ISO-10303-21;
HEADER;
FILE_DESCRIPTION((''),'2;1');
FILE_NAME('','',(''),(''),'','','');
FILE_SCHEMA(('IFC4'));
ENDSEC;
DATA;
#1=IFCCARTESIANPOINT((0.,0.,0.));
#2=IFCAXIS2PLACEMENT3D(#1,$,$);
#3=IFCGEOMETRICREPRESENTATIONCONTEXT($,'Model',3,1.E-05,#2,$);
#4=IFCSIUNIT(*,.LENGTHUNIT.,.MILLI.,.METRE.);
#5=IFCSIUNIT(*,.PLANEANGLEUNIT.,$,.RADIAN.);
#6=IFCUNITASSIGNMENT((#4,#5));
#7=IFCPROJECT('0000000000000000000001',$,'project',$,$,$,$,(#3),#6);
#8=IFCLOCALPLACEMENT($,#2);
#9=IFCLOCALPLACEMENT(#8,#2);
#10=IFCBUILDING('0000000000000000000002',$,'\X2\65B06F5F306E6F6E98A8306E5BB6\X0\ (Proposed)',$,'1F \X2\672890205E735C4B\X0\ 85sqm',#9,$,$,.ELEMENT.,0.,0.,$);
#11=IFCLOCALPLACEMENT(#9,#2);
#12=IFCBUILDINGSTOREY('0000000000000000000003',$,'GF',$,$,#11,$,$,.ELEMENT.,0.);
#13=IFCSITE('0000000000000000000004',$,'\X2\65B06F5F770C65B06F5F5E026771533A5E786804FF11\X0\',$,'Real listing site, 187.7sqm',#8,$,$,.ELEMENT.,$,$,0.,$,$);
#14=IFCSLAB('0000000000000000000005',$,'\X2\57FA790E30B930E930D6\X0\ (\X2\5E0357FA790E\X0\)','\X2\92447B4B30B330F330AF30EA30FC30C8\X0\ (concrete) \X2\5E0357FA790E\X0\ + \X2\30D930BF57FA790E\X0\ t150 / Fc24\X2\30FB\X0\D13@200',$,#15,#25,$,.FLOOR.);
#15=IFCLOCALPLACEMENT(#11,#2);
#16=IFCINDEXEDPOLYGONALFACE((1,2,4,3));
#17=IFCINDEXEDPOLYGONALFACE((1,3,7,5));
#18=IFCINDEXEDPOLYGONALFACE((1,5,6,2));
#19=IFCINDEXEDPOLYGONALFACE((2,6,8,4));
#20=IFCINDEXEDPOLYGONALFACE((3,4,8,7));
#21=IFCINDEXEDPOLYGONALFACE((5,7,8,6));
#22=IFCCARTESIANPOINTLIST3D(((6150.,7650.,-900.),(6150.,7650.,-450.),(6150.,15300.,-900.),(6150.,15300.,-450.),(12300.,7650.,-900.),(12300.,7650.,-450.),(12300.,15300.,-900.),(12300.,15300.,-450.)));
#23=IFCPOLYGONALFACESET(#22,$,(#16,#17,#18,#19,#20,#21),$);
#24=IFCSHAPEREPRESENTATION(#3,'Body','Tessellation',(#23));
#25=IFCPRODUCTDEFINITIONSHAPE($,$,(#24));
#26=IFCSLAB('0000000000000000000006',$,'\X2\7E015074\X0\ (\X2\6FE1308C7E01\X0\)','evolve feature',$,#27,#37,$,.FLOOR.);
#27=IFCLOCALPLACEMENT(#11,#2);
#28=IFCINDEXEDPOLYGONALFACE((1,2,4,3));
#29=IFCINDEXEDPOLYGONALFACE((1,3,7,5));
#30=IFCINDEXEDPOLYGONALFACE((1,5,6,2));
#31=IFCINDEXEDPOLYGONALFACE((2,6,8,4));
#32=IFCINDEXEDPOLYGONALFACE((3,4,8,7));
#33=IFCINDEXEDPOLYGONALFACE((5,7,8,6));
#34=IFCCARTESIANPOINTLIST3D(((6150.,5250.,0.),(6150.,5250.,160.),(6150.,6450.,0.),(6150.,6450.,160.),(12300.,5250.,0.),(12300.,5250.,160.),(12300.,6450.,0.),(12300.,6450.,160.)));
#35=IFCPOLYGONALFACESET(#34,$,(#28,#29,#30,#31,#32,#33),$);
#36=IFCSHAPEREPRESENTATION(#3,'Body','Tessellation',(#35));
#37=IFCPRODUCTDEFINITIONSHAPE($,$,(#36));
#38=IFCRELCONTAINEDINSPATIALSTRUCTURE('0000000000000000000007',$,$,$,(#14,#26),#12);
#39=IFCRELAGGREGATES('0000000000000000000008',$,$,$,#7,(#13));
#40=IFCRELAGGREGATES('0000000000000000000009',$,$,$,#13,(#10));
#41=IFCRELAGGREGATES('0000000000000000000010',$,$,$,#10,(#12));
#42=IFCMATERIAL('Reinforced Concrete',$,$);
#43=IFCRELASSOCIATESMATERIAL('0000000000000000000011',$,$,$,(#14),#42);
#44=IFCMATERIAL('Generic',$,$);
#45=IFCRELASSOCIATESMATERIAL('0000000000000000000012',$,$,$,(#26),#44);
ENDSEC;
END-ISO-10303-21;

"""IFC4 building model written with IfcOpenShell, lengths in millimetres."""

from ifc_helpers import new_model, si_unit, frame, frame_2d, origin, place, context, project, spatial, rectangle, extrude, material, element, save


model = new_model("IFC4")

# Units and contexts
model_context = context("Model", 3, precision=1e-05, world=origin())
ifc_project = project(units=[si_unit("LENGTHUNIT", "METRE", prefix="MILLI"), si_unit("PLANEANGLEUNIT", "RADIAN")], contexts=[model_context])

# Site, building, storey
site_placement = place(None, origin())
site = spatial("IfcSite", under=ifc_project, at=site_placement, Name="新潟県新潟市東区幸栄１", ObjectType="Real listing site, 187.7sqm", CompositionType="ELEMENT", RefElevation=0.0)
building_placement = place(site_placement, origin())
building = spatial("IfcBuilding", under=site, at=building_placement, Name="新潟の潮風の家 (Proposed)", ObjectType="1F 木造平屋 85sqm", CompositionType="ELEMENT", ElevationOfRefHeight=0.0, ElevationOfTerrain=0.0)
storey_placement = place(building_placement, origin())
storey = spatial("IfcBuildingStorey", under=building, at=storey_placement, Name="GF", CompositionType="ELEMENT", Elevation=0.0)

# Slabs
ifc_material_1 = material(Name="Reinforced Concrete")
slab_1_placement = place(storey_placement, frame((3075.0, 3825.0, -450.0)))
element("IfcSlab", 1, at=slab_1_placement, inside=storey, material=ifc_material_1, Name="基礎スラブ (布基礎)", Description="鉄筋コンクリート (concrete) 布基礎 + ベタ基礎 t150 / Fc24・D13@200", PredefinedType="FLOOR", context=model_context, shape_type="SweptSolid", body=[
    extrude(rectangle(XDim=6150.0, YDim=7650.0, at=frame_2d((3075.0, 3825.0))), frame((3075.0, 3825.0, -450.0)), (0.0, 0.0, 1.0), 450.0),
])
ifc_material_2 = material(Name="Generic")
slab_2_placement = place(storey_placement, frame((3075.0, 2625.0, 0.0)))
element("IfcSlab", 2, at=slab_2_placement, inside=storey, material=ifc_material_2, Name="縁側 (濡れ縁)", Description="evolve feature", PredefinedType="FLOOR", context=model_context, shape_type="SweptSolid", body=[
    extrude(rectangle(XDim=6150.0, YDim=1200.0, at=frame_2d((3075.0, 600.0))), frame((3075.0, 2625.0, 0.0)), (0.0, 0.0, 1.0), 160.0),
])

save(model, "model.ifc")
